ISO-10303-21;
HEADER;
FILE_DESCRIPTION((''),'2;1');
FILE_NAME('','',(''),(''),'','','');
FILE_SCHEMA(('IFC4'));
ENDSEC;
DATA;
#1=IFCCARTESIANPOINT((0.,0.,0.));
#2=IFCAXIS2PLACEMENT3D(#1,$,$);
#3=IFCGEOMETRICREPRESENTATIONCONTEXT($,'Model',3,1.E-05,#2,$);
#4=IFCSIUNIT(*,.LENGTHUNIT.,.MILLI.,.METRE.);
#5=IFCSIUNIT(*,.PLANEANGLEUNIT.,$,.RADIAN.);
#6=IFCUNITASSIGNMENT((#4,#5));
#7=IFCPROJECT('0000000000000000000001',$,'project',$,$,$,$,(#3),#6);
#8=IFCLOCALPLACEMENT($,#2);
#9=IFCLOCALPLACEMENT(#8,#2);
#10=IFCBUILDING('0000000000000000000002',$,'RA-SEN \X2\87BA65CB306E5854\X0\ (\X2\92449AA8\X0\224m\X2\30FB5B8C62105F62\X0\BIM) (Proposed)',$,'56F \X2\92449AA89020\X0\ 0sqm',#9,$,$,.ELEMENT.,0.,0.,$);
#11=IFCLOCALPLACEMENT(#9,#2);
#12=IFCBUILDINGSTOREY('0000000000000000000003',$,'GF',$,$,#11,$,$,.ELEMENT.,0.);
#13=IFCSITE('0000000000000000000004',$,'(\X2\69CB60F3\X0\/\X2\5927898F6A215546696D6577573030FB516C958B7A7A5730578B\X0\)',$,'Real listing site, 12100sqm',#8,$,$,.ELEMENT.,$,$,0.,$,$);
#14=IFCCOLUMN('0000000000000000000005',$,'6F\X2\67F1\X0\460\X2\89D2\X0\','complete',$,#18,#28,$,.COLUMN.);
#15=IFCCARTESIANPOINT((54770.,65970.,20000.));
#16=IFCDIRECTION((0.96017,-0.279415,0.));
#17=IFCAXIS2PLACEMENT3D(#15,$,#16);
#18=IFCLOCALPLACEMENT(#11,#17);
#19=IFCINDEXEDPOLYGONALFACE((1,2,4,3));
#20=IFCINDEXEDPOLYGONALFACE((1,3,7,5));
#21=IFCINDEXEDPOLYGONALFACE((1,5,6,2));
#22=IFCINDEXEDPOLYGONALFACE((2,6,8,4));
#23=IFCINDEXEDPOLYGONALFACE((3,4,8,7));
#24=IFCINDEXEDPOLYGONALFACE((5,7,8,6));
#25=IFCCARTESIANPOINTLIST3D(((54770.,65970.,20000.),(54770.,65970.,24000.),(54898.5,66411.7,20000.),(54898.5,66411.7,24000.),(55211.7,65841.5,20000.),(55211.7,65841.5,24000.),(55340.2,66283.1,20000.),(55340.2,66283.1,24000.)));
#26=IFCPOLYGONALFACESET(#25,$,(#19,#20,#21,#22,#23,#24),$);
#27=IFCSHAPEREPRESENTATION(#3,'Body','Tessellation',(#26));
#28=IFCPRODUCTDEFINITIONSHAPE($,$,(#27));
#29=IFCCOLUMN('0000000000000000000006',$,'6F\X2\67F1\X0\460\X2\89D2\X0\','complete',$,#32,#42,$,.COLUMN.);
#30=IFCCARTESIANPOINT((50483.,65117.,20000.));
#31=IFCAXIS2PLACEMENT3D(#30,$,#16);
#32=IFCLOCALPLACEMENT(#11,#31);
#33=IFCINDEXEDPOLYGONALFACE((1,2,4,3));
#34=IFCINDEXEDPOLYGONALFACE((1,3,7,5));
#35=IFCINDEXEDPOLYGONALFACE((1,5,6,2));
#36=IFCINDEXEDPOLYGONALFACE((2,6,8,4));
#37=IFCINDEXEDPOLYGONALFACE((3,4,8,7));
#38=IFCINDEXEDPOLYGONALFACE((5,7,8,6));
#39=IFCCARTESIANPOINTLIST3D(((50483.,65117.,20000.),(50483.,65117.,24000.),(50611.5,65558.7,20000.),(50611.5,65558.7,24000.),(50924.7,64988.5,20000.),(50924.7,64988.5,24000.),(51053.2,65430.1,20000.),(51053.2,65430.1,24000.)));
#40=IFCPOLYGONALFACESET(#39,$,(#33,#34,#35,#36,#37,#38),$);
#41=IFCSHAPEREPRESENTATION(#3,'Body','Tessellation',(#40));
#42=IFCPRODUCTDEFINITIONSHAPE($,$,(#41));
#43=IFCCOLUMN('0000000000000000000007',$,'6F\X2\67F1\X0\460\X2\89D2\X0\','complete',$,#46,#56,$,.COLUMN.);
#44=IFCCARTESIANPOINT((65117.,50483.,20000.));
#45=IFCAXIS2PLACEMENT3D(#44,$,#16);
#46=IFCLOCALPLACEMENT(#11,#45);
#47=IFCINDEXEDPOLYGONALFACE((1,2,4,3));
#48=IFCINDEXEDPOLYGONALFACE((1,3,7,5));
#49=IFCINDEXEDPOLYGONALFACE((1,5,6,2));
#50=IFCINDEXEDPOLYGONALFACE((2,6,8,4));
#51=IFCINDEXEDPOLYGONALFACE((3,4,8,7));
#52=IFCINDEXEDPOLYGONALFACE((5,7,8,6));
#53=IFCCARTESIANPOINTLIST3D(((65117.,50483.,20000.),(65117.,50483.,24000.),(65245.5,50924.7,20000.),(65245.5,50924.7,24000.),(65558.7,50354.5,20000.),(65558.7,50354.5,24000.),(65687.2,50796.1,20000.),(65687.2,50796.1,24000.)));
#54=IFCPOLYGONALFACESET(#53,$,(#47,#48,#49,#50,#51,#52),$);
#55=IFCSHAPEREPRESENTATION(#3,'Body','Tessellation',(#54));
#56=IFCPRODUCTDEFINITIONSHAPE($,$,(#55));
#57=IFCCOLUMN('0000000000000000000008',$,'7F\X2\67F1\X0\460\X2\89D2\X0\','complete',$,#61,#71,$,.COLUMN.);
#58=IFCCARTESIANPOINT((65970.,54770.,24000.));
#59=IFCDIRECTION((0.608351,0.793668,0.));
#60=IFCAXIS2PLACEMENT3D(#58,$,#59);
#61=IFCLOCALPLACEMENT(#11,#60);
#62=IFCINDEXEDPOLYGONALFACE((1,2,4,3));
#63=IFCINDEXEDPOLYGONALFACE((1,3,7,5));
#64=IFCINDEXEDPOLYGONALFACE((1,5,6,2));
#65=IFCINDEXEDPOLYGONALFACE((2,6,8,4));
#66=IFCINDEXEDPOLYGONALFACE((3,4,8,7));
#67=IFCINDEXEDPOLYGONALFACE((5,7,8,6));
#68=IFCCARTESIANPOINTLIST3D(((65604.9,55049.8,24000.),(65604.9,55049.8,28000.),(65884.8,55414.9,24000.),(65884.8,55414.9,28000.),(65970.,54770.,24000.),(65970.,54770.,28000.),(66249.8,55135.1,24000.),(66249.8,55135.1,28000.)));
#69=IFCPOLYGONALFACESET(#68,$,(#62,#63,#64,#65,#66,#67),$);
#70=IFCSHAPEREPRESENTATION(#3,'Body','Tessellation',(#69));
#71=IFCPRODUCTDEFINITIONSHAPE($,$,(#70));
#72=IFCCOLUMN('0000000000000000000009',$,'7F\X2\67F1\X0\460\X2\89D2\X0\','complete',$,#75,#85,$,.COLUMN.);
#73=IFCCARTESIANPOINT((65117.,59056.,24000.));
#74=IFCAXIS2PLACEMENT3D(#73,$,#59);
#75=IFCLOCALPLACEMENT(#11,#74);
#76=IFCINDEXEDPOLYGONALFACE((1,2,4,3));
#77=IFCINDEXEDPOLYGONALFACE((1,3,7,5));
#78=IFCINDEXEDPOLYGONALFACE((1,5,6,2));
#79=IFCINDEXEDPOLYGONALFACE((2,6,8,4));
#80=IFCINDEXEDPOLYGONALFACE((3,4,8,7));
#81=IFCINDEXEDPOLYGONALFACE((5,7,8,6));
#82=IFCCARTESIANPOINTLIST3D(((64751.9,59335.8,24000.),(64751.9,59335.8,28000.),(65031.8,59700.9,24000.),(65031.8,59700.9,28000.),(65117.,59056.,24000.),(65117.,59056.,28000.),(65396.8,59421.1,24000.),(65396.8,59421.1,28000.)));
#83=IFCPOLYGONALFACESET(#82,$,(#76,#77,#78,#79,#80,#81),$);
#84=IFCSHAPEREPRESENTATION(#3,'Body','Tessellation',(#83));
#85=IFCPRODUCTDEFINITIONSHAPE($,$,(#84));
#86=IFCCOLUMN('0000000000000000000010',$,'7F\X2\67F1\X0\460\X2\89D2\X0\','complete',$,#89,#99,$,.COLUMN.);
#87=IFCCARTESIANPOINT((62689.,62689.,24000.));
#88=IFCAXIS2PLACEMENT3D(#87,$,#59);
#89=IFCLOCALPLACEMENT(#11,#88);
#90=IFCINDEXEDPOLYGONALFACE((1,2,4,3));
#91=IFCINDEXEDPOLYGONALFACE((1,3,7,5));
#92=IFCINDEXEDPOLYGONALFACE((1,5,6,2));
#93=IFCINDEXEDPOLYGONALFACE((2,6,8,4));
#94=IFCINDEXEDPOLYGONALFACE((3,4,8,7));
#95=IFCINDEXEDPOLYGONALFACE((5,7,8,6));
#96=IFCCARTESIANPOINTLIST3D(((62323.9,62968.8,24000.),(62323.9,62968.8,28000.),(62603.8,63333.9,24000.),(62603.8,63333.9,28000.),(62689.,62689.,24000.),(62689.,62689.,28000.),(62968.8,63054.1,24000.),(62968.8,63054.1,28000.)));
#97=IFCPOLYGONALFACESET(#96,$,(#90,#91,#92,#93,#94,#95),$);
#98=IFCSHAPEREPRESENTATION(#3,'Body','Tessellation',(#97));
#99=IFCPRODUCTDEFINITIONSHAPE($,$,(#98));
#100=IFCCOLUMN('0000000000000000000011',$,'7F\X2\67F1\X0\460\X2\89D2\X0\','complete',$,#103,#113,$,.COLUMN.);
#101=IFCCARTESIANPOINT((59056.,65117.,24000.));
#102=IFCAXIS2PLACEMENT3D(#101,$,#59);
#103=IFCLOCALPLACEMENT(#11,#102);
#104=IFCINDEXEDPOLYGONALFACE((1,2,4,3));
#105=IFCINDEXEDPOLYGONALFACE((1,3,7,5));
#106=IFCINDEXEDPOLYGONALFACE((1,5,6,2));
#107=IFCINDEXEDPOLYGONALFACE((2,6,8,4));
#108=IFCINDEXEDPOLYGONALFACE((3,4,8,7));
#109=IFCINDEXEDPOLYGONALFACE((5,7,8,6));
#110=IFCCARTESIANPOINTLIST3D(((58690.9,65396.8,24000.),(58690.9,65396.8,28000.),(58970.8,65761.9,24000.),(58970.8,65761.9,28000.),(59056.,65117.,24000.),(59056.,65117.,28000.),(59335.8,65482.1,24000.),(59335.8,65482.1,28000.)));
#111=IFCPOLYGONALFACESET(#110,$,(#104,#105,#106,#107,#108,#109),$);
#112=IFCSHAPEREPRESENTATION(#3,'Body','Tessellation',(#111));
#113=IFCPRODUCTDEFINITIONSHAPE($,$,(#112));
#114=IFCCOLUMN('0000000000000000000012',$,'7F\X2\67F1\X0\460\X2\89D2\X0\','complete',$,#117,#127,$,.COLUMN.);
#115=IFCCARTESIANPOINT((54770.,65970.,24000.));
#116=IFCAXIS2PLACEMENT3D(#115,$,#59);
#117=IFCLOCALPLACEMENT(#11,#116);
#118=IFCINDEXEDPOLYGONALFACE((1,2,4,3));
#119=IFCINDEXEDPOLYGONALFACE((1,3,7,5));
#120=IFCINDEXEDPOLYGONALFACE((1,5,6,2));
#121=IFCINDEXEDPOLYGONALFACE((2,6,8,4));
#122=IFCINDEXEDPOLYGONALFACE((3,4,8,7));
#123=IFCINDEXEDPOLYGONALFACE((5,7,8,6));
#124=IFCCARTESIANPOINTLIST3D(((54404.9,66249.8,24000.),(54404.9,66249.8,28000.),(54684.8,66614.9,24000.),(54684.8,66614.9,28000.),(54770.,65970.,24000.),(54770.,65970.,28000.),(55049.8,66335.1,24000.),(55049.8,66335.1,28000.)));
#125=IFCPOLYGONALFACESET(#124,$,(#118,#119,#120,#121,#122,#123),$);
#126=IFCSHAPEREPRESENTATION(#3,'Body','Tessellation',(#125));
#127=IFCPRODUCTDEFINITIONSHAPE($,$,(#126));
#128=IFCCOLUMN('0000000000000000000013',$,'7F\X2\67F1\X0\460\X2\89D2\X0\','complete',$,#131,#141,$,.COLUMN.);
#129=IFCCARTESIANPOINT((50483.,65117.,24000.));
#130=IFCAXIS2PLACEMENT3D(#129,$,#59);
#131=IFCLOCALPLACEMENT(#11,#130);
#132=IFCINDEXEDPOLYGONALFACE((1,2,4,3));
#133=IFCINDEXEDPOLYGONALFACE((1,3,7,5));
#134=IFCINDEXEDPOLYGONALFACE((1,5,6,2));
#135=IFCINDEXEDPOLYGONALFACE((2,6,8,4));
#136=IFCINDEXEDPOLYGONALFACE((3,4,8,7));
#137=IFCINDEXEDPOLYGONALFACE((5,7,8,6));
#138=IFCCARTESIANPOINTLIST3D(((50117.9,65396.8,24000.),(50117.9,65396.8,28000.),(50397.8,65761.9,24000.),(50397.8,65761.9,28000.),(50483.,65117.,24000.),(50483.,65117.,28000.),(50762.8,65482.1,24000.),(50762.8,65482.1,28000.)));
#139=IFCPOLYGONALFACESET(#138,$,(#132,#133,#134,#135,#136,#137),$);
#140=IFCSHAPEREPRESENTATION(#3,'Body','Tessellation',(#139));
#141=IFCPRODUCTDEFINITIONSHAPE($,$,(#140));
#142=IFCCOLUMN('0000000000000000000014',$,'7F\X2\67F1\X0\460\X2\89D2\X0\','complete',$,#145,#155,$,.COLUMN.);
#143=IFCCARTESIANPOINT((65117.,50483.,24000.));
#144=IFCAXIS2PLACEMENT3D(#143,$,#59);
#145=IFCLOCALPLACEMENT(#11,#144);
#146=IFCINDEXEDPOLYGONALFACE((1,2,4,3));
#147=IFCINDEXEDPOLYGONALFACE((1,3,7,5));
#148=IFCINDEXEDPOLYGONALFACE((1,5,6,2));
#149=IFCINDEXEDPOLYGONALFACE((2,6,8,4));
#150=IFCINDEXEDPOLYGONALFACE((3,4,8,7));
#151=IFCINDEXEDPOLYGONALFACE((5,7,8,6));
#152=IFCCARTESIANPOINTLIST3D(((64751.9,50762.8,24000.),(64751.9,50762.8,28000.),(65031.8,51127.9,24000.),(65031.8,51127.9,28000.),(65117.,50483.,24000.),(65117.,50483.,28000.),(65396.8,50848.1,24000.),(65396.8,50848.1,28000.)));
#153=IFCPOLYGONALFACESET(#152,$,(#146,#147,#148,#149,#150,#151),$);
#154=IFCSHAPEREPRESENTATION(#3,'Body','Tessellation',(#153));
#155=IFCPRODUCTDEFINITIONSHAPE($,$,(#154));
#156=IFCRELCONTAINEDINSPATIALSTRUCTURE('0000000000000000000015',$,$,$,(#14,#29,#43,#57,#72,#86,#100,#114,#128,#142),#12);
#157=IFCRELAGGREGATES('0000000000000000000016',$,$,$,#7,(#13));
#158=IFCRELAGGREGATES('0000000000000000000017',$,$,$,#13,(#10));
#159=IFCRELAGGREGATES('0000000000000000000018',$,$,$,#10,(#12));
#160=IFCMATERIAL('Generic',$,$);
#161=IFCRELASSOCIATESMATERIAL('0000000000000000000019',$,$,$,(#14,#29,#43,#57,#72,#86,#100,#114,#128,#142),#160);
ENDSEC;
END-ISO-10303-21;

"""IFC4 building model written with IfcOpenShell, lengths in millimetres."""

from ifc_helpers import new_model, si_unit, frame, frame_2d, origin, place, context, project, spatial, rectangle, extrude, material, element, save


model = new_model("IFC4")

# Units and contexts
model_context = context("Model", 3, precision=1e-05, world=origin())
ifc_project = project(units=[si_unit("LENGTHUNIT", "METRE", prefix="MILLI"), si_unit("PLANEANGLEUNIT", "RADIAN")], contexts=[model_context])

# Site, building, storey
site_placement = place(None, origin())
site = spatial("IfcSite", under=ifc_project, at=site_placement, Name="(構想/大規模商業敷地・公開空地型)", ObjectType="Real listing site, 12100sqm", CompositionType="ELEMENT", RefElevation=0.0)
building_placement = place(site_placement, origin())
building = spatial("IfcBuilding", under=site, at=building_placement, Name="RA-SEN 螺旋の塔 (鉄骨224m・完成形BIM) (Proposed)", ObjectType="56F 鉄骨造 0sqm", CompositionType="ELEMENT", ElevationOfRefHeight=0.0, ElevationOfTerrain=0.0)
storey_placement = place(building_placement, origin())
storey = spatial("IfcBuildingStorey", under=building, at=storey_placement, Name="GF", CompositionType="ELEMENT", Elevation=0.0)

# Columns
ifc_material = material(Name="Generic")
column_1_placement = place(storey_placement, frame((54770.0, 65970.0, 20000.0), x_axis=(0.96017, -0.279415, 0.0)))
element("IfcColumn", 1, at=column_1_placement, inside=storey, material=ifc_material, Name="6F柱460角", Description="complete", PredefinedType="COLUMN", context=model_context, shape_type="SweptSolid", body=[
    extrude(rectangle(XDim=460.0, YDim=460.0, at=frame_2d((230.0, 230.0))), frame((54770.0, 65970.0, 20000.0), x_axis=(0.96017, -0.279415, 0.0)), (0.0, 0.0, 1.0), 4000.0),
])
column_2_placement = place(storey_placement, frame((50483.0, 65117.0, 20000.0), x_axis=(0.96017, -0.279415, 0.0)))
element("IfcColumn", 2, at=column_2_placement, inside=storey, material=ifc_material, Name="6F柱460角", Description="complete", PredefinedType="COLUMN", context=model_context, shape_type="SweptSolid", body=[
    extrude(rectangle(XDim=460.0, YDim=460.0, at=frame_2d((230.0, 230.0))), frame((50483.0, 65117.0, 20000.0), x_axis=(0.96017, -0.279415, 0.0)), (0.0, 0.0, 1.0), 4000.0),
])
column_3_placement = place(storey_placement, frame((65117.0, 50483.0, 20000.0), x_axis=(0.96017, -0.279415, 0.0)))
element("IfcColumn", 3, at=column_3_placement, inside=storey, material=ifc_material, Name="6F柱460角", Description="complete", PredefinedType="COLUMN", context=model_context, shape_type="SweptSolid", body=[
    extrude(rectangle(XDim=460.0, YDim=460.0, at=frame_2d((230.0, 230.0))), frame((65117.0, 50483.0, 20000.0), x_axis=(0.96017, -0.279415, 0.0)), (0.0, 0.0, 1.0), 4000.0),
])
column_4_placement = place(storey_placement, frame((65970.0, 54770.0, 24000.0), x_axis=(0.608351, 0.793668, 0.0)))
element("IfcColumn", 4, at=column_4_placement, inside=storey, material=ifc_material, Name="7F柱460角", Description="complete", PredefinedType="COLUMN", context=model_context, shape_type="SweptSolid", body=[
    extrude(rectangle(XDim=460.0, YDim=460.0, at=frame_2d((230.0, 230.0))), frame((65970.0, 54770.0, 24000.0), x_axis=(0.608351, 0.793668, 0.0)), (0.0, 0.0, 1.0), 4000.0),
])
column_5_placement = place(storey_placement, frame((65117.0, 59056.0, 24000.0), x_axis=(0.608351, 0.793668, 0.0)))
element("IfcColumn", 5, at=column_5_placement, inside=storey, material=ifc_material, Name="7F柱460角", Description="complete", PredefinedType="COLUMN", context=model_context, shape_type="SweptSolid", body=[
    extrude(rectangle(XDim=460.0, YDim=460.0, at=frame_2d((230.0, 230.0))), frame((65117.0, 59056.0, 24000.0), x_axis=(0.608351, 0.793668, 0.0)), (0.0, 0.0, 1.0), 4000.0),
])
column_6_placement = place(storey_placement, frame((62689.0, 62689.0, 24000.0), x_axis=(0.608351, 0.793668, 0.0)))
element("IfcColumn", 6, at=column_6_placement, inside=storey, material=ifc_material, Name="7F柱460角", Description="complete", PredefinedType="COLUMN", context=model_context, shape_type="SweptSolid", body=[
    extrude(rectangle(XDim=460.0, YDim=460.0, at=frame_2d((230.0, 230.0))), frame((62689.0, 62689.0, 24000.0), x_axis=(0.608351, 0.793668, 0.0)), (0.0, 0.0, 1.0), 4000.0),
])
column_7_placement = place(storey_placement, frame((59056.0, 65117.0, 24000.0), x_axis=(0.608351, 0.793668, 0.0)))
element("IfcColumn", 7, at=column_7_placement, inside=storey, material=ifc_material, Name="7F柱460角", Description="complete", PredefinedType="COLUMN", context=model_context, shape_type="SweptSolid", body=[
    extrude(rectangle(XDim=460.0, YDim=460.0, at=frame_2d((230.0, 230.0))), frame((59056.0, 65117.0, 24000.0), x_axis=(0.608351, 0.793668, 0.0)), (0.0, 0.0, 1.0), 4000.0),
])
column_8_placement = place(storey_placement, frame((54770.0, 65970.0, 24000.0), x_axis=(0.608351, 0.793668, 0.0)))
element("IfcColumn", 8, at=column_8_placement, inside=storey, material=ifc_material, Name="7F柱460角", Description="complete", PredefinedType="COLUMN", context=model_context, shape_type="SweptSolid", body=[
    extrude(rectangle(XDim=460.0, YDim=460.0, at=frame_2d((230.0, 230.0))), frame((54770.0, 65970.0, 24000.0), x_axis=(0.608351, 0.793668, 0.0)), (0.0, 0.0, 1.0), 4000.0),
])
column_9_placement = place(storey_placement, frame((50483.0, 65117.0, 24000.0), x_axis=(0.608351, 0.793668, 0.0)))
element("IfcColumn", 9, at=column_9_placement, inside=storey, material=ifc_material, Name="7F柱460角", Description="complete", PredefinedType="COLUMN", context=model_context, shape_type="SweptSolid", body=[
    extrude(rectangle(XDim=460.0, YDim=460.0, at=frame_2d((230.0, 230.0))), frame((50483.0, 65117.0, 24000.0), x_axis=(0.608351, 0.793668, 0.0)), (0.0, 0.0, 1.0), 4000.0),
])
column_10_placement = place(storey_placement, frame((65117.0, 50483.0, 24000.0), x_axis=(0.608351, 0.793668, 0.0)))
element("IfcColumn", 10, at=column_10_placement, inside=storey, material=ifc_material, Name="7F柱460角", Description="complete", PredefinedType="COLUMN", context=model_context, shape_type="SweptSolid", body=[
    extrude(rectangle(XDim=460.0, YDim=460.0, at=frame_2d((230.0, 230.0))), frame((65117.0, 50483.0, 24000.0), x_axis=(0.608351, 0.793668, 0.0)), (0.0, 0.0, 1.0), 4000.0),
])

save(model, "model.ifc")
